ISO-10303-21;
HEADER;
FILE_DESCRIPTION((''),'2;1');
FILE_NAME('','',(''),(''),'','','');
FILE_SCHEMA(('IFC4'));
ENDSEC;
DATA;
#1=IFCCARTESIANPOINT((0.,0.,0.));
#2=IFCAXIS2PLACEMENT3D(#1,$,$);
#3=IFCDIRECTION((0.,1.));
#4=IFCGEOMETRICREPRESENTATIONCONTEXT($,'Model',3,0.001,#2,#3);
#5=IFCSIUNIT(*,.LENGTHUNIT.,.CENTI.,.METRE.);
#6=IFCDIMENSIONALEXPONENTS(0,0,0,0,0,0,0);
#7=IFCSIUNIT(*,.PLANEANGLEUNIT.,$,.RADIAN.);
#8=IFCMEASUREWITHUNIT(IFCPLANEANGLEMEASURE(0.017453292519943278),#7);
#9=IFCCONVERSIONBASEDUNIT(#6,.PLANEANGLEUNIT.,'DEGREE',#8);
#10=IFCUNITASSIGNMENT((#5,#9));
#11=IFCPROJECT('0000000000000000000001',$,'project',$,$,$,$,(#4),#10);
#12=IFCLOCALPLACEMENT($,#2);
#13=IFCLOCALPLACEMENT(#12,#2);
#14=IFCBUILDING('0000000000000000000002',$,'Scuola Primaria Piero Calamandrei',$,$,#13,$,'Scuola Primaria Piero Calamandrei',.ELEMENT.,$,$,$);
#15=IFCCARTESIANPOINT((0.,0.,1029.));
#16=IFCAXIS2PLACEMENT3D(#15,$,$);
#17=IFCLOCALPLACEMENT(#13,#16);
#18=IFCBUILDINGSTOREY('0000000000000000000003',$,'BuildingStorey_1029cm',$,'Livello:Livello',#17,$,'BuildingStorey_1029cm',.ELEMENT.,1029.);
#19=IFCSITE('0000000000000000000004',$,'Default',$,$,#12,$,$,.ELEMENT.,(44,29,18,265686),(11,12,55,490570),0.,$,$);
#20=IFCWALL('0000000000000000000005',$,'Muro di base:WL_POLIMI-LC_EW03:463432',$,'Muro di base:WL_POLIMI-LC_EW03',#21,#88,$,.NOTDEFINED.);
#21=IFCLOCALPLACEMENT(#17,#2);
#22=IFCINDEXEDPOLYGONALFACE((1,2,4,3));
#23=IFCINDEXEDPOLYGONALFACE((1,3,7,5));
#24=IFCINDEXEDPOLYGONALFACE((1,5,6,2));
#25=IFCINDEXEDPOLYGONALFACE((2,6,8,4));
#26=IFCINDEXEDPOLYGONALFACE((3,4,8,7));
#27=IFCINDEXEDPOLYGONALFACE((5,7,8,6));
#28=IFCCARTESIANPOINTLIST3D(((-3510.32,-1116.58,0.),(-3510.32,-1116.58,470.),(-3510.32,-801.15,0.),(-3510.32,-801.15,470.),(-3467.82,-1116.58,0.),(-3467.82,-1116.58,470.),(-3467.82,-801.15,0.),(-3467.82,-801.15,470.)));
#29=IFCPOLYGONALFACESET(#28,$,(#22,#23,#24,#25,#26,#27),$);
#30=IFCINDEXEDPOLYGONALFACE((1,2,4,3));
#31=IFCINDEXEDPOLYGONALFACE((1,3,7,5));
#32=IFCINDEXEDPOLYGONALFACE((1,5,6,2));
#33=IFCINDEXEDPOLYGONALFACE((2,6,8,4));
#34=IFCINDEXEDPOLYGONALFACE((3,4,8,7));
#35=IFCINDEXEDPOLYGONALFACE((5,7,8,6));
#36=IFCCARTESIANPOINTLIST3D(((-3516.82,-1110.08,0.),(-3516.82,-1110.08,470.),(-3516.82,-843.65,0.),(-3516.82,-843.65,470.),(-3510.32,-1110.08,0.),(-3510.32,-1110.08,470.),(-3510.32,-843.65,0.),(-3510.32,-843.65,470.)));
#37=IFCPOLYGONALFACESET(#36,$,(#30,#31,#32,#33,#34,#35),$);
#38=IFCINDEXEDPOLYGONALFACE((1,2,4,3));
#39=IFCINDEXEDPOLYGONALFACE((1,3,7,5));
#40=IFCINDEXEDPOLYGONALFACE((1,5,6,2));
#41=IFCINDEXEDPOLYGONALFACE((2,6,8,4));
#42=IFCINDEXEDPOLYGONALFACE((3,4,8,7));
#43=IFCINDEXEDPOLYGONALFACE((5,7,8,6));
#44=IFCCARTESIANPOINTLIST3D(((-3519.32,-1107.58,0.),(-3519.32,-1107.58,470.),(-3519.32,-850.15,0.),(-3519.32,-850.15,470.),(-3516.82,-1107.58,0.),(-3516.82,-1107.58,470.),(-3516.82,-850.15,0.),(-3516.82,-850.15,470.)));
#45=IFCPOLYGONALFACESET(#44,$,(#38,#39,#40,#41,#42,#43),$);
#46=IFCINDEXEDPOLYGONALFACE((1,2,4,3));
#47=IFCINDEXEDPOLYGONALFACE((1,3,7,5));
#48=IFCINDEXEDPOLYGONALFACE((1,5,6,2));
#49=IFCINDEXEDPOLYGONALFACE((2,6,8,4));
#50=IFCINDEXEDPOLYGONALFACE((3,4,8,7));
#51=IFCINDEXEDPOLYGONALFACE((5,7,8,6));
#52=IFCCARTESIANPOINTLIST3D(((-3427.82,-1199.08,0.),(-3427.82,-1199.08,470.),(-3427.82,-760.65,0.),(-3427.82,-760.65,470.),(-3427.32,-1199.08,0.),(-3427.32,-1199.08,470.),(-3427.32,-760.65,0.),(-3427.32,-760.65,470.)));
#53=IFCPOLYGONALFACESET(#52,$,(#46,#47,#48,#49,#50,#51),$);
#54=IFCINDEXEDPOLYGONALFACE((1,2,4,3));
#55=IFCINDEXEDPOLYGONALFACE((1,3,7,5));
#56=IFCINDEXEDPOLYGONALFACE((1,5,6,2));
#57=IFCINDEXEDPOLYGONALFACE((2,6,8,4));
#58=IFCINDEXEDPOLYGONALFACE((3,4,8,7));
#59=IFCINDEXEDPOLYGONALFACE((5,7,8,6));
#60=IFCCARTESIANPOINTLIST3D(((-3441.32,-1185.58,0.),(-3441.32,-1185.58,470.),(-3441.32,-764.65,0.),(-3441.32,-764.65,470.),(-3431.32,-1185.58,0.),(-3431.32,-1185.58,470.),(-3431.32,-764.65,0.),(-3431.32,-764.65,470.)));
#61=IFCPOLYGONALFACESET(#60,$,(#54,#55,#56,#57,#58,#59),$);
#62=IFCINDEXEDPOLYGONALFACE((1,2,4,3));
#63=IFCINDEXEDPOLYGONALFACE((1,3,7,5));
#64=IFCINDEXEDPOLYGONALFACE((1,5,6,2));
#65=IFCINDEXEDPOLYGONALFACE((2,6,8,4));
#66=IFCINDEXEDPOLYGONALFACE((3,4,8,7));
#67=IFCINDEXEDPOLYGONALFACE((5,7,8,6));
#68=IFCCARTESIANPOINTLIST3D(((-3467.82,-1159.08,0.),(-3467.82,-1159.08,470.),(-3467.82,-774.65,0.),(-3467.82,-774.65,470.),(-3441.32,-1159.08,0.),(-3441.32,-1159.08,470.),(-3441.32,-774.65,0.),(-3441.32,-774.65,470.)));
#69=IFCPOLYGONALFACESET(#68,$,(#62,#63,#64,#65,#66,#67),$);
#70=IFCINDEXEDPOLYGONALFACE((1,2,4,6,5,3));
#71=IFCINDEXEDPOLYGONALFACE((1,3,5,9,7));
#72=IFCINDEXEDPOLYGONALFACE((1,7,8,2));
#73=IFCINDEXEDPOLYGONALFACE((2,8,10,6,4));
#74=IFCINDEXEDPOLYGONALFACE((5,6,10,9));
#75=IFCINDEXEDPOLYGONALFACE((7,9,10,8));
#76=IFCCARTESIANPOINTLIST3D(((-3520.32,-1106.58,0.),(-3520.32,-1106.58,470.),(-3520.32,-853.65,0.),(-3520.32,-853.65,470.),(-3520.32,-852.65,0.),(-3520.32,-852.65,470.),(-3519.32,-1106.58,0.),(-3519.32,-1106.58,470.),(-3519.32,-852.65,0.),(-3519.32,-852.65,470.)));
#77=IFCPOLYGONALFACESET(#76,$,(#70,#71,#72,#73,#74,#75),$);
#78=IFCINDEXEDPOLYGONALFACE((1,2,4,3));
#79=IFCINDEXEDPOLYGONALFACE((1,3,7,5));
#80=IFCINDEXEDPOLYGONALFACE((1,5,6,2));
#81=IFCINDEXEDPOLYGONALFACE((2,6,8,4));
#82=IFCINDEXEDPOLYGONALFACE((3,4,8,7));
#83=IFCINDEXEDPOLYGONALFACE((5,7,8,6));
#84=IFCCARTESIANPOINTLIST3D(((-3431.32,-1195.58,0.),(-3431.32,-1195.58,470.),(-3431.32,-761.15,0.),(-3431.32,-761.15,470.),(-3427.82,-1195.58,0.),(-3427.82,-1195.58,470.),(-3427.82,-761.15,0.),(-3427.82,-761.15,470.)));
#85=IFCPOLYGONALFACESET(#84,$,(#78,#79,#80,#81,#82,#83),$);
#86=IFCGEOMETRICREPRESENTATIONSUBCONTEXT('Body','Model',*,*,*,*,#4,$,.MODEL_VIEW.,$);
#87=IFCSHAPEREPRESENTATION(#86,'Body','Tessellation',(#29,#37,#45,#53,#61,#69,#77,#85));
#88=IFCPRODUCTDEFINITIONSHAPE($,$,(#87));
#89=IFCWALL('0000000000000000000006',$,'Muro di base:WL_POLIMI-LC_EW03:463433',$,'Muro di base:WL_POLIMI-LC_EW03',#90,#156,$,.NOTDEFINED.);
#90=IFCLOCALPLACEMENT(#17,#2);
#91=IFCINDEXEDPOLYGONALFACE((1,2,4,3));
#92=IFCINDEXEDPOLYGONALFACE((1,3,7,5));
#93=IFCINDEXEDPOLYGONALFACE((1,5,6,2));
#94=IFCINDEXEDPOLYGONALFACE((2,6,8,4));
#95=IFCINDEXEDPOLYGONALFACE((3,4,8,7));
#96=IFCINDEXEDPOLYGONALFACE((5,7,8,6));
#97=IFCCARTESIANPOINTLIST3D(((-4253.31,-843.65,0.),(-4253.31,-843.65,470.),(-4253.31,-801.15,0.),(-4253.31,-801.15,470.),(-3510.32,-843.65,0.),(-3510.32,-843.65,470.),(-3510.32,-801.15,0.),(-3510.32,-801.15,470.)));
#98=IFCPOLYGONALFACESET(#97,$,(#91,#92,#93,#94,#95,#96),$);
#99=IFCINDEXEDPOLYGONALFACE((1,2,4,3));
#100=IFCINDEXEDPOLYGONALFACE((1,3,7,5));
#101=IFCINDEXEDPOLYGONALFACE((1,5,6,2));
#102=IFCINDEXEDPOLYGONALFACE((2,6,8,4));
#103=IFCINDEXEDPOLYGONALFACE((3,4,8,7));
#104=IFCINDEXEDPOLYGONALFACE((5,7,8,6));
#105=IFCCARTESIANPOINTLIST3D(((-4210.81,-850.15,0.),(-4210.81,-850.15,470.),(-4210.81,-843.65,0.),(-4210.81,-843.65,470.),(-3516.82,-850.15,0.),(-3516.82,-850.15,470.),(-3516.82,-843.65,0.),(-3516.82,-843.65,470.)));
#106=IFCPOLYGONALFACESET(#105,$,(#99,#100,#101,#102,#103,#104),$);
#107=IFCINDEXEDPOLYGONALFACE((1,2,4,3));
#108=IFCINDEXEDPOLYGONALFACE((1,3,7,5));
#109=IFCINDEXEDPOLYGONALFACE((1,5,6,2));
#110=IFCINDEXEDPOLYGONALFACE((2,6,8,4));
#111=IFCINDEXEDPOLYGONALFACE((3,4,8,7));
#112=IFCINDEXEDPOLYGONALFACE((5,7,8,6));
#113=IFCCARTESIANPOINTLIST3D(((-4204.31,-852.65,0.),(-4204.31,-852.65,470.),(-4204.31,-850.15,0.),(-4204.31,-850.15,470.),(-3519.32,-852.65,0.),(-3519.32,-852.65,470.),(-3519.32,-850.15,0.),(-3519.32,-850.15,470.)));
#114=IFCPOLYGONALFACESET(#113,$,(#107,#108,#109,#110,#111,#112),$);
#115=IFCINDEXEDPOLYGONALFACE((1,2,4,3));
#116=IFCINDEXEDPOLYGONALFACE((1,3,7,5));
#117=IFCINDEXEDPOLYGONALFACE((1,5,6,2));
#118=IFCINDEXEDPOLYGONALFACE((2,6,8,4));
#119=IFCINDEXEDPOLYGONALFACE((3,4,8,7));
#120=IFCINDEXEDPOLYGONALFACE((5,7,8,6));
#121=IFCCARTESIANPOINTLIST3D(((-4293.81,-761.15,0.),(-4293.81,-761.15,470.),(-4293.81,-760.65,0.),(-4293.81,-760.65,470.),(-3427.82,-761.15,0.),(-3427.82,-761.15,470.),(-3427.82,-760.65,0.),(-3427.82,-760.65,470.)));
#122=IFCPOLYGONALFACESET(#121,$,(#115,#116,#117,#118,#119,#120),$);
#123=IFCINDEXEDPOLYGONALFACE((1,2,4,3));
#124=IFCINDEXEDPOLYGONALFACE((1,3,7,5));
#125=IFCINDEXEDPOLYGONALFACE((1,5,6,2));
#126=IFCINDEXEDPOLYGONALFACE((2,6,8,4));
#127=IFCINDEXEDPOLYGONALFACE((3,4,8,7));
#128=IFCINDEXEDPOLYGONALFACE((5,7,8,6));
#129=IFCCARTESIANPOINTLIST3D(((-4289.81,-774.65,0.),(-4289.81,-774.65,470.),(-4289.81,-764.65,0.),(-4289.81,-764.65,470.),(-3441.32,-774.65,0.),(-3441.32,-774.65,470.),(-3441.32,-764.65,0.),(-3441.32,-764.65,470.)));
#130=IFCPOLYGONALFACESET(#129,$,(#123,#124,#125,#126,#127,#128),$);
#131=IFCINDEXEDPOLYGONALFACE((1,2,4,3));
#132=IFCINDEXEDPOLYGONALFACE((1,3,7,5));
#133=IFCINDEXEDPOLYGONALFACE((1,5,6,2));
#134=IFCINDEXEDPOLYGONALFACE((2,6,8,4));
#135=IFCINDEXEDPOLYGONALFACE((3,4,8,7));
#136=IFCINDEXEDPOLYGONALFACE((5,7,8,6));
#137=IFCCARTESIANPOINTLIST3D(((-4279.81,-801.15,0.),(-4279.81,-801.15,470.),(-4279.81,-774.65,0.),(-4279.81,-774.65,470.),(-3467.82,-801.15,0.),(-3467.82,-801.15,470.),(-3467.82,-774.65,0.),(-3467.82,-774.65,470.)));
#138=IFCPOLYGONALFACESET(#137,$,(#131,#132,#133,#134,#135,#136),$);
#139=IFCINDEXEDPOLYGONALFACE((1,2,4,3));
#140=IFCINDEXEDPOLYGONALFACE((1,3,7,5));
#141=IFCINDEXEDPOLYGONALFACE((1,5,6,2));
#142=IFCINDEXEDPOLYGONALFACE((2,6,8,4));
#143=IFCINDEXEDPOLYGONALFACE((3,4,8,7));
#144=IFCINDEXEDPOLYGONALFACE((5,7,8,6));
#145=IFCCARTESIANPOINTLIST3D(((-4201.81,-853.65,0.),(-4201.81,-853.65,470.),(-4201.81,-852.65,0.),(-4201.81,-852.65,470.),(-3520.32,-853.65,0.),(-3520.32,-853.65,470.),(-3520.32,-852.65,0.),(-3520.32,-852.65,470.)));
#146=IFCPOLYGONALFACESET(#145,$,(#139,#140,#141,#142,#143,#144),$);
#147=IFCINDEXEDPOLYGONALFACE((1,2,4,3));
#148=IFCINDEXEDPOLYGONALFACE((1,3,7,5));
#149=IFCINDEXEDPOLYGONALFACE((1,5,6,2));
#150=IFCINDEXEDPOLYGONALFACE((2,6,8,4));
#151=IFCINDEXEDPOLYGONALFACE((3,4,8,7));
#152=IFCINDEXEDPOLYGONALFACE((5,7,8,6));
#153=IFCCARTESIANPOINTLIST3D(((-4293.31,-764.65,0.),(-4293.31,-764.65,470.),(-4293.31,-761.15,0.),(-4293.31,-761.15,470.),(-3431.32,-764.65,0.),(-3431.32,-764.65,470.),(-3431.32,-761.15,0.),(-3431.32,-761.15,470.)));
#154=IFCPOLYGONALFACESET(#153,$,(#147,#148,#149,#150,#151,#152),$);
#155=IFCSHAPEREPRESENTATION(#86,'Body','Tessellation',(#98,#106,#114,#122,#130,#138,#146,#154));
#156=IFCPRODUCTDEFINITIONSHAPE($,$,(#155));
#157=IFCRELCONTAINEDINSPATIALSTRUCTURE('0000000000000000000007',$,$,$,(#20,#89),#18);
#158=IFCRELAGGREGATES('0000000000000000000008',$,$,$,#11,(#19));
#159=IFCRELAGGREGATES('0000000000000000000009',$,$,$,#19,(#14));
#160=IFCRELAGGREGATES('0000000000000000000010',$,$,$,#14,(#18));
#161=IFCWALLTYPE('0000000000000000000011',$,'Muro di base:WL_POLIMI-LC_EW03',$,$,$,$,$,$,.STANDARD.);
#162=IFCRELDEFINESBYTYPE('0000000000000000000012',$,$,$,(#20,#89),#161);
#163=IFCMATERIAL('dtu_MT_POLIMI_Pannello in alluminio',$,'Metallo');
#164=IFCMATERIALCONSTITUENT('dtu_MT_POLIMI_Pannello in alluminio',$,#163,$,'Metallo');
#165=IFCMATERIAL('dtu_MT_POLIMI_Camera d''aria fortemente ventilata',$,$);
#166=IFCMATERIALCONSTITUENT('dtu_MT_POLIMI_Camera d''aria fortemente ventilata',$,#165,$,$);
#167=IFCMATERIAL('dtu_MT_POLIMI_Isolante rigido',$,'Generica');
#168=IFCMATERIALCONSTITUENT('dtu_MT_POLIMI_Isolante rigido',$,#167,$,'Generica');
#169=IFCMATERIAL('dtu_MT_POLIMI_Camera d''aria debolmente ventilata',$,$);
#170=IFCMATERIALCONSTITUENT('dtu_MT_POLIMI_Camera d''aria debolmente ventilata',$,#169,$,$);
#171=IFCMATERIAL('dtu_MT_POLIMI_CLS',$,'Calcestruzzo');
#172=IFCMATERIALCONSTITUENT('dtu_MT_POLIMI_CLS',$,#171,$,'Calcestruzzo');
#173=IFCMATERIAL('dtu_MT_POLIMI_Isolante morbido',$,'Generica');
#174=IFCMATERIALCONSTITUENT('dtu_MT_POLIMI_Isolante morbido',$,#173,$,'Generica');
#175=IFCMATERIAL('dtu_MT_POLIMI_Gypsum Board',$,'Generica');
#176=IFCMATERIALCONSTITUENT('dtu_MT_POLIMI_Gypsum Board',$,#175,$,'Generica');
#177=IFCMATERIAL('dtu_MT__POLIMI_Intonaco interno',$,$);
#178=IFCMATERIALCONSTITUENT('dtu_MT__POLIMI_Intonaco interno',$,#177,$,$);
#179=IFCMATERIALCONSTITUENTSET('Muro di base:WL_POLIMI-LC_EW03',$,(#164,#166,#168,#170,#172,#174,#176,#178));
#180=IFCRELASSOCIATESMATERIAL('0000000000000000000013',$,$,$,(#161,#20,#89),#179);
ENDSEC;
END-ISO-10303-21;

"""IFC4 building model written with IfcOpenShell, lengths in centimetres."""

from ifc_helpers import new_model, entity, si_unit, converted_unit, direction, frame, origin, place, context, subcontext, project, spatial, indexed_curve, outline, extrude, material, constituent, constituent_set, type_object, element, save


model = new_model("IFC4")

# Units and contexts
model_context = context("Model", 3, precision=0.001, world=origin(), true_north=direction((0.0, 1.0)))
body_context = subcontext(model_context, "Body", "Model", "MODEL_VIEW")
ifc_project = project(units=[si_unit("LENGTHUNIT", "METRE", prefix="CENTI"), converted_unit("PLANEANGLEUNIT", "DEGREE", entity("IfcPlaneAngleMeasure", 0.017453292519943278), si_unit("PLANEANGLEUNIT", "RADIAN"), dimensions=[0, 0, 0, 0, 0, 0, 0])], contexts=[model_context])

# Site, building, storey
site_placement = place(None, origin())
site = spatial("IfcSite", under=ifc_project, at=site_placement, Name="Default", CompositionType="ELEMENT", RefLatitude=(44, 29, 18, 265686), RefLongitude=(11, 12, 55, 490570), RefElevation=0.0)
building_placement = place(site_placement, origin())
building = spatial("IfcBuilding", under=site, at=building_placement, Name="Scuola Primaria Piero Calamandrei", LongName="Scuola Primaria Piero Calamandrei", CompositionType="ELEMENT")
storey_placement = place(building_placement, frame((0.0, 0.0, 1029.0)))
storey = spatial("IfcBuildingStorey", under=building, at=storey_placement, Name="BuildingStorey_1029cm", ObjectType="Livello:Livello", LongName="BuildingStorey_1029cm", CompositionType="ELEMENT", Elevation=1029.0)

# Shared definitions
ifc_material_1 = material(Name="dtu_MT_POLIMI_Isolante rigido", Category="Generica")
ifc_material_2 = material(Name="dtu_MT__POLIMI_Intonaco interno")

# Shared definitions
ifc_material_3 = material(Name="dtu_MT_POLIMI_CLS", Category="Calcestruzzo")

# Shared definitions
ifc_material_4 = material(Name="dtu_MT_POLIMI_Pannello in alluminio", Category="Metallo")
ifc_constituent_1 = constituent(ifc_material_4, Name="dtu_MT_POLIMI_Pannello in alluminio", Category="Metallo")
ifc_material_5 = material(Name="dtu_MT_POLIMI_Camera d'aria fortemente ventilata")
ifc_constituent_2 = constituent(ifc_material_5, Name="dtu_MT_POLIMI_Camera d'aria fortemente ventilata")
ifc_constituent_3 = constituent(ifc_material_1, Name="dtu_MT_POLIMI_Isolante rigido", Category="Generica")
ifc_material_6 = material(Name="dtu_MT_POLIMI_Camera d'aria debolmente ventilata")
ifc_constituent_4 = constituent(ifc_material_6, Name="dtu_MT_POLIMI_Camera d'aria debolmente ventilata")
ifc_constituent_5 = constituent(ifc_material_3, Name="dtu_MT_POLIMI_CLS", Category="Calcestruzzo")
ifc_material_7 = material(Name="dtu_MT_POLIMI_Isolante morbido", Category="Generica")
ifc_constituent_6 = constituent(ifc_material_7, Name="dtu_MT_POLIMI_Isolante morbido", Category="Generica")
ifc_material_8 = material(Name="dtu_MT_POLIMI_Gypsum Board", Category="Generica")
ifc_constituent_7 = constituent(ifc_material_8, Name="dtu_MT_POLIMI_Gypsum Board", Category="Generica")
ifc_constituent_8 = constituent(ifc_material_2, Name="dtu_MT__POLIMI_Intonaco interno")
ifc_constituent_set_1 = constituent_set(constituents=[ifc_constituent_1, ifc_constituent_2, ifc_constituent_3, ifc_constituent_4, ifc_constituent_5, ifc_constituent_6, ifc_constituent_7, ifc_constituent_8], Name="Muro di base:WL_POLIMI-LC_EW03")
wall_type = type_object("IfcWallType", Name="Muro di base:WL_POLIMI-LC_EW03", PredefinedType="STANDARD", material=ifc_constituent_set_1)

# Walls
wall_1_placement = place(storey_placement, frame((-3473.82, -760.65, 0.0), z_axis=(0.0, 0.0, 1.0), x_axis=(0.0, -1.0, 0.0)))
element("IfcWall", 1, at=wall_1_placement, inside=storey, type_object=wall_type, material=ifc_constituent_set_1, Name="Muro di base:WL_POLIMI-LC_EW03:463432", ObjectType="Muro di base:WL_POLIMI-LC_EW03", PredefinedType="NOTDEFINED", context=body_context, shape_type="SweptSolid", body=[
    extrude(outline(indexed_curve([(-157.71, -21.25), (157.71, -21.25), (157.71, 21.25), (-157.71, 21.25), (-157.71, -21.25)], self_intersect=False)), frame((198.21, -15.25, 0.0)), (0.0, 0.0, 1.0), 470.0),
    extrude(outline(indexed_curve([(-133.21, -3.25), (133.21, -3.25), (133.21, 3.25), (-133.21, 3.25), (-133.21, -3.25)], self_intersect=False)), frame((216.21, -39.75, 0.0)), (0.0, 0.0, 1.0), 470.0),
    extrude(outline(indexed_curve([(-128.71, -1.25), (128.71, -1.25), (128.71, 1.25), (-128.71, 1.25), (-128.71, -1.25)], self_intersect=False)), frame((218.21, -44.25, 0.0)), (0.0, 0.0, 1.0), 470.0),
    extrude(outline(indexed_curve([(-0.25, -219.21), (0.25, -219.21), (0.25, 219.21), (-0.25, 219.21), (-0.25, -219.21)], self_intersect=False)), frame((219.21, 46.25, 0.0), z_axis=(0.0, 0.0, 1.0), x_axis=(0.0, -1.0, 0.0)), (0.0, 0.0, 1.0), 470.0),
    extrude(outline(indexed_curve([(-210.46, -5.0), (210.46, -5.0), (210.46, 5.0), (-210.46, 5.0), (-210.46, -5.0)], self_intersect=False)), frame((214.46, 37.5, 0.0)), (0.0, 0.0, 1.0), 470.0),
    extrude(outline(indexed_curve([(-192.21, -13.25), (192.21, -13.25), (192.21, 13.25), (-192.21, 13.25), (-192.21, -13.25)], self_intersect=False)), frame((206.21, 19.25, 0.0)), (0.0, 0.0, 1.0), 470.0),
    extrude(outline(indexed_curve([(-100.77, -0.4), (152.15, -0.4), (152.15, 0.6), (-101.77, 0.6), (-101.77, -0.4), (-100.77, -0.4)], self_intersect=False)), frame((193.77, -46.1, 0.0)), (0.0, 0.0, 1.0), 470.0),
    extrude(outline(indexed_curve([(-217.21, -1.75), (217.21, -1.75), (217.21, 1.75), (-217.21, 1.75), (-217.21, -1.75)], self_intersect=False)), frame((217.71, 44.25, 0.0)), (0.0, 0.0, 1.0), 470.0),
])
wall_2_placement = place(storey_placement, frame((-4293.81, -807.15, 0.0)))
element("IfcWall", 2, at=wall_2_placement, inside=storey, type_object=wall_type, material=ifc_constituent_set_1, Name="Muro di base:WL_POLIMI-LC_EW03:463433", ObjectType="Muro di base:WL_POLIMI-LC_EW03", PredefinedType="NOTDEFINED", context=body_context, shape_type="SweptSolid", body=[
    extrude(outline(indexed_curve([(-235.0, -21.25), (235.0, -21.25), (235.0, 21.25), (-235.0, 21.25), (-235.0, -21.25)], self_intersect=False)), frame((40.5, -15.25, 235.0), z_axis=(1.0, 0.0, 0.0), x_axis=(0.0, 0.0, 1.0)), (0.0, 0.0, 1.0), 742.99),
    extrude(outline(indexed_curve([(-235.0, -3.25), (235.0, -3.25), (235.0, 3.25), (-235.0, 3.25), (-235.0, -3.25)], self_intersect=False)), frame((83.0, -39.75, 235.0), z_axis=(1.0, 0.0, 0.0), x_axis=(0.0, 0.0, 1.0)), (0.0, 0.0, 1.0), 693.99),
    extrude(outline(indexed_curve([(-235.0, -1.25), (235.0, -1.25), (235.0, 1.25), (-235.0, 1.25), (-235.0, -1.25)], self_intersect=False)), frame((89.5, -44.25, 235.0), z_axis=(1.0, 0.0, 0.0), x_axis=(0.0, 0.0, 1.0)), (0.0, 0.0, 1.0), 684.99),
    extrude(outline(indexed_curve([(-0.25, -235.0), (0.25, -235.0), (0.25, 235.0), (-0.25, 235.0), (-0.25, -235.0)], self_intersect=False)), frame((0.0, 46.25, 235.0), z_axis=(1.0, 0.0, 0.0), x_axis=(0.0, -1.0, 0.0)), (0.0, 0.0, 1.0), 865.99),
    extrude(outline(indexed_curve([(-235.0, -5.0), (235.0, -5.0), (235.0, 5.0), (-235.0, 5.0), (-235.0, -5.0)], self_intersect=False)), frame((4.0, 37.5, 235.0), z_axis=(1.0, 0.0, 0.0), x_axis=(0.0, 0.0, 1.0)), (0.0, 0.0, 1.0), 848.49),
    extrude(outline(indexed_curve([(-235.0, -13.25), (235.0, -13.25), (235.0, 13.25), (-235.0, 13.25), (-235.0, -13.25)], self_intersect=False)), frame((14.0, 19.25, 235.0), z_axis=(1.0, 0.0, 0.0), x_axis=(0.0, 0.0, 1.0)), (0.0, 0.0, 1.0), 811.99),
    extrude(outline(indexed_curve([(-0.5, -235.0), (0.5, -235.0), (0.5, 235.0), (-0.5, 235.0), (-0.5, -235.0)], self_intersect=False)), frame((92.0, -46.0, 235.0), z_axis=(1.0, 0.0, 0.0), x_axis=(0.0, 1.0, 0.0)), (0.0, 0.0, 1.0), 681.49),
    extrude(outline(indexed_curve([(-235.0, -1.75), (235.0, -1.75), (235.0, 1.75), (-235.0, 1.75), (-235.0, -1.75)], self_intersect=False)), frame((0.5, 44.25, 235.0), z_axis=(1.0, 0.0, 0.0), x_axis=(0.0, 0.0, 1.0)), (0.0, 0.0, 1.0), 861.99),
])

save(model, "model.ifc")
